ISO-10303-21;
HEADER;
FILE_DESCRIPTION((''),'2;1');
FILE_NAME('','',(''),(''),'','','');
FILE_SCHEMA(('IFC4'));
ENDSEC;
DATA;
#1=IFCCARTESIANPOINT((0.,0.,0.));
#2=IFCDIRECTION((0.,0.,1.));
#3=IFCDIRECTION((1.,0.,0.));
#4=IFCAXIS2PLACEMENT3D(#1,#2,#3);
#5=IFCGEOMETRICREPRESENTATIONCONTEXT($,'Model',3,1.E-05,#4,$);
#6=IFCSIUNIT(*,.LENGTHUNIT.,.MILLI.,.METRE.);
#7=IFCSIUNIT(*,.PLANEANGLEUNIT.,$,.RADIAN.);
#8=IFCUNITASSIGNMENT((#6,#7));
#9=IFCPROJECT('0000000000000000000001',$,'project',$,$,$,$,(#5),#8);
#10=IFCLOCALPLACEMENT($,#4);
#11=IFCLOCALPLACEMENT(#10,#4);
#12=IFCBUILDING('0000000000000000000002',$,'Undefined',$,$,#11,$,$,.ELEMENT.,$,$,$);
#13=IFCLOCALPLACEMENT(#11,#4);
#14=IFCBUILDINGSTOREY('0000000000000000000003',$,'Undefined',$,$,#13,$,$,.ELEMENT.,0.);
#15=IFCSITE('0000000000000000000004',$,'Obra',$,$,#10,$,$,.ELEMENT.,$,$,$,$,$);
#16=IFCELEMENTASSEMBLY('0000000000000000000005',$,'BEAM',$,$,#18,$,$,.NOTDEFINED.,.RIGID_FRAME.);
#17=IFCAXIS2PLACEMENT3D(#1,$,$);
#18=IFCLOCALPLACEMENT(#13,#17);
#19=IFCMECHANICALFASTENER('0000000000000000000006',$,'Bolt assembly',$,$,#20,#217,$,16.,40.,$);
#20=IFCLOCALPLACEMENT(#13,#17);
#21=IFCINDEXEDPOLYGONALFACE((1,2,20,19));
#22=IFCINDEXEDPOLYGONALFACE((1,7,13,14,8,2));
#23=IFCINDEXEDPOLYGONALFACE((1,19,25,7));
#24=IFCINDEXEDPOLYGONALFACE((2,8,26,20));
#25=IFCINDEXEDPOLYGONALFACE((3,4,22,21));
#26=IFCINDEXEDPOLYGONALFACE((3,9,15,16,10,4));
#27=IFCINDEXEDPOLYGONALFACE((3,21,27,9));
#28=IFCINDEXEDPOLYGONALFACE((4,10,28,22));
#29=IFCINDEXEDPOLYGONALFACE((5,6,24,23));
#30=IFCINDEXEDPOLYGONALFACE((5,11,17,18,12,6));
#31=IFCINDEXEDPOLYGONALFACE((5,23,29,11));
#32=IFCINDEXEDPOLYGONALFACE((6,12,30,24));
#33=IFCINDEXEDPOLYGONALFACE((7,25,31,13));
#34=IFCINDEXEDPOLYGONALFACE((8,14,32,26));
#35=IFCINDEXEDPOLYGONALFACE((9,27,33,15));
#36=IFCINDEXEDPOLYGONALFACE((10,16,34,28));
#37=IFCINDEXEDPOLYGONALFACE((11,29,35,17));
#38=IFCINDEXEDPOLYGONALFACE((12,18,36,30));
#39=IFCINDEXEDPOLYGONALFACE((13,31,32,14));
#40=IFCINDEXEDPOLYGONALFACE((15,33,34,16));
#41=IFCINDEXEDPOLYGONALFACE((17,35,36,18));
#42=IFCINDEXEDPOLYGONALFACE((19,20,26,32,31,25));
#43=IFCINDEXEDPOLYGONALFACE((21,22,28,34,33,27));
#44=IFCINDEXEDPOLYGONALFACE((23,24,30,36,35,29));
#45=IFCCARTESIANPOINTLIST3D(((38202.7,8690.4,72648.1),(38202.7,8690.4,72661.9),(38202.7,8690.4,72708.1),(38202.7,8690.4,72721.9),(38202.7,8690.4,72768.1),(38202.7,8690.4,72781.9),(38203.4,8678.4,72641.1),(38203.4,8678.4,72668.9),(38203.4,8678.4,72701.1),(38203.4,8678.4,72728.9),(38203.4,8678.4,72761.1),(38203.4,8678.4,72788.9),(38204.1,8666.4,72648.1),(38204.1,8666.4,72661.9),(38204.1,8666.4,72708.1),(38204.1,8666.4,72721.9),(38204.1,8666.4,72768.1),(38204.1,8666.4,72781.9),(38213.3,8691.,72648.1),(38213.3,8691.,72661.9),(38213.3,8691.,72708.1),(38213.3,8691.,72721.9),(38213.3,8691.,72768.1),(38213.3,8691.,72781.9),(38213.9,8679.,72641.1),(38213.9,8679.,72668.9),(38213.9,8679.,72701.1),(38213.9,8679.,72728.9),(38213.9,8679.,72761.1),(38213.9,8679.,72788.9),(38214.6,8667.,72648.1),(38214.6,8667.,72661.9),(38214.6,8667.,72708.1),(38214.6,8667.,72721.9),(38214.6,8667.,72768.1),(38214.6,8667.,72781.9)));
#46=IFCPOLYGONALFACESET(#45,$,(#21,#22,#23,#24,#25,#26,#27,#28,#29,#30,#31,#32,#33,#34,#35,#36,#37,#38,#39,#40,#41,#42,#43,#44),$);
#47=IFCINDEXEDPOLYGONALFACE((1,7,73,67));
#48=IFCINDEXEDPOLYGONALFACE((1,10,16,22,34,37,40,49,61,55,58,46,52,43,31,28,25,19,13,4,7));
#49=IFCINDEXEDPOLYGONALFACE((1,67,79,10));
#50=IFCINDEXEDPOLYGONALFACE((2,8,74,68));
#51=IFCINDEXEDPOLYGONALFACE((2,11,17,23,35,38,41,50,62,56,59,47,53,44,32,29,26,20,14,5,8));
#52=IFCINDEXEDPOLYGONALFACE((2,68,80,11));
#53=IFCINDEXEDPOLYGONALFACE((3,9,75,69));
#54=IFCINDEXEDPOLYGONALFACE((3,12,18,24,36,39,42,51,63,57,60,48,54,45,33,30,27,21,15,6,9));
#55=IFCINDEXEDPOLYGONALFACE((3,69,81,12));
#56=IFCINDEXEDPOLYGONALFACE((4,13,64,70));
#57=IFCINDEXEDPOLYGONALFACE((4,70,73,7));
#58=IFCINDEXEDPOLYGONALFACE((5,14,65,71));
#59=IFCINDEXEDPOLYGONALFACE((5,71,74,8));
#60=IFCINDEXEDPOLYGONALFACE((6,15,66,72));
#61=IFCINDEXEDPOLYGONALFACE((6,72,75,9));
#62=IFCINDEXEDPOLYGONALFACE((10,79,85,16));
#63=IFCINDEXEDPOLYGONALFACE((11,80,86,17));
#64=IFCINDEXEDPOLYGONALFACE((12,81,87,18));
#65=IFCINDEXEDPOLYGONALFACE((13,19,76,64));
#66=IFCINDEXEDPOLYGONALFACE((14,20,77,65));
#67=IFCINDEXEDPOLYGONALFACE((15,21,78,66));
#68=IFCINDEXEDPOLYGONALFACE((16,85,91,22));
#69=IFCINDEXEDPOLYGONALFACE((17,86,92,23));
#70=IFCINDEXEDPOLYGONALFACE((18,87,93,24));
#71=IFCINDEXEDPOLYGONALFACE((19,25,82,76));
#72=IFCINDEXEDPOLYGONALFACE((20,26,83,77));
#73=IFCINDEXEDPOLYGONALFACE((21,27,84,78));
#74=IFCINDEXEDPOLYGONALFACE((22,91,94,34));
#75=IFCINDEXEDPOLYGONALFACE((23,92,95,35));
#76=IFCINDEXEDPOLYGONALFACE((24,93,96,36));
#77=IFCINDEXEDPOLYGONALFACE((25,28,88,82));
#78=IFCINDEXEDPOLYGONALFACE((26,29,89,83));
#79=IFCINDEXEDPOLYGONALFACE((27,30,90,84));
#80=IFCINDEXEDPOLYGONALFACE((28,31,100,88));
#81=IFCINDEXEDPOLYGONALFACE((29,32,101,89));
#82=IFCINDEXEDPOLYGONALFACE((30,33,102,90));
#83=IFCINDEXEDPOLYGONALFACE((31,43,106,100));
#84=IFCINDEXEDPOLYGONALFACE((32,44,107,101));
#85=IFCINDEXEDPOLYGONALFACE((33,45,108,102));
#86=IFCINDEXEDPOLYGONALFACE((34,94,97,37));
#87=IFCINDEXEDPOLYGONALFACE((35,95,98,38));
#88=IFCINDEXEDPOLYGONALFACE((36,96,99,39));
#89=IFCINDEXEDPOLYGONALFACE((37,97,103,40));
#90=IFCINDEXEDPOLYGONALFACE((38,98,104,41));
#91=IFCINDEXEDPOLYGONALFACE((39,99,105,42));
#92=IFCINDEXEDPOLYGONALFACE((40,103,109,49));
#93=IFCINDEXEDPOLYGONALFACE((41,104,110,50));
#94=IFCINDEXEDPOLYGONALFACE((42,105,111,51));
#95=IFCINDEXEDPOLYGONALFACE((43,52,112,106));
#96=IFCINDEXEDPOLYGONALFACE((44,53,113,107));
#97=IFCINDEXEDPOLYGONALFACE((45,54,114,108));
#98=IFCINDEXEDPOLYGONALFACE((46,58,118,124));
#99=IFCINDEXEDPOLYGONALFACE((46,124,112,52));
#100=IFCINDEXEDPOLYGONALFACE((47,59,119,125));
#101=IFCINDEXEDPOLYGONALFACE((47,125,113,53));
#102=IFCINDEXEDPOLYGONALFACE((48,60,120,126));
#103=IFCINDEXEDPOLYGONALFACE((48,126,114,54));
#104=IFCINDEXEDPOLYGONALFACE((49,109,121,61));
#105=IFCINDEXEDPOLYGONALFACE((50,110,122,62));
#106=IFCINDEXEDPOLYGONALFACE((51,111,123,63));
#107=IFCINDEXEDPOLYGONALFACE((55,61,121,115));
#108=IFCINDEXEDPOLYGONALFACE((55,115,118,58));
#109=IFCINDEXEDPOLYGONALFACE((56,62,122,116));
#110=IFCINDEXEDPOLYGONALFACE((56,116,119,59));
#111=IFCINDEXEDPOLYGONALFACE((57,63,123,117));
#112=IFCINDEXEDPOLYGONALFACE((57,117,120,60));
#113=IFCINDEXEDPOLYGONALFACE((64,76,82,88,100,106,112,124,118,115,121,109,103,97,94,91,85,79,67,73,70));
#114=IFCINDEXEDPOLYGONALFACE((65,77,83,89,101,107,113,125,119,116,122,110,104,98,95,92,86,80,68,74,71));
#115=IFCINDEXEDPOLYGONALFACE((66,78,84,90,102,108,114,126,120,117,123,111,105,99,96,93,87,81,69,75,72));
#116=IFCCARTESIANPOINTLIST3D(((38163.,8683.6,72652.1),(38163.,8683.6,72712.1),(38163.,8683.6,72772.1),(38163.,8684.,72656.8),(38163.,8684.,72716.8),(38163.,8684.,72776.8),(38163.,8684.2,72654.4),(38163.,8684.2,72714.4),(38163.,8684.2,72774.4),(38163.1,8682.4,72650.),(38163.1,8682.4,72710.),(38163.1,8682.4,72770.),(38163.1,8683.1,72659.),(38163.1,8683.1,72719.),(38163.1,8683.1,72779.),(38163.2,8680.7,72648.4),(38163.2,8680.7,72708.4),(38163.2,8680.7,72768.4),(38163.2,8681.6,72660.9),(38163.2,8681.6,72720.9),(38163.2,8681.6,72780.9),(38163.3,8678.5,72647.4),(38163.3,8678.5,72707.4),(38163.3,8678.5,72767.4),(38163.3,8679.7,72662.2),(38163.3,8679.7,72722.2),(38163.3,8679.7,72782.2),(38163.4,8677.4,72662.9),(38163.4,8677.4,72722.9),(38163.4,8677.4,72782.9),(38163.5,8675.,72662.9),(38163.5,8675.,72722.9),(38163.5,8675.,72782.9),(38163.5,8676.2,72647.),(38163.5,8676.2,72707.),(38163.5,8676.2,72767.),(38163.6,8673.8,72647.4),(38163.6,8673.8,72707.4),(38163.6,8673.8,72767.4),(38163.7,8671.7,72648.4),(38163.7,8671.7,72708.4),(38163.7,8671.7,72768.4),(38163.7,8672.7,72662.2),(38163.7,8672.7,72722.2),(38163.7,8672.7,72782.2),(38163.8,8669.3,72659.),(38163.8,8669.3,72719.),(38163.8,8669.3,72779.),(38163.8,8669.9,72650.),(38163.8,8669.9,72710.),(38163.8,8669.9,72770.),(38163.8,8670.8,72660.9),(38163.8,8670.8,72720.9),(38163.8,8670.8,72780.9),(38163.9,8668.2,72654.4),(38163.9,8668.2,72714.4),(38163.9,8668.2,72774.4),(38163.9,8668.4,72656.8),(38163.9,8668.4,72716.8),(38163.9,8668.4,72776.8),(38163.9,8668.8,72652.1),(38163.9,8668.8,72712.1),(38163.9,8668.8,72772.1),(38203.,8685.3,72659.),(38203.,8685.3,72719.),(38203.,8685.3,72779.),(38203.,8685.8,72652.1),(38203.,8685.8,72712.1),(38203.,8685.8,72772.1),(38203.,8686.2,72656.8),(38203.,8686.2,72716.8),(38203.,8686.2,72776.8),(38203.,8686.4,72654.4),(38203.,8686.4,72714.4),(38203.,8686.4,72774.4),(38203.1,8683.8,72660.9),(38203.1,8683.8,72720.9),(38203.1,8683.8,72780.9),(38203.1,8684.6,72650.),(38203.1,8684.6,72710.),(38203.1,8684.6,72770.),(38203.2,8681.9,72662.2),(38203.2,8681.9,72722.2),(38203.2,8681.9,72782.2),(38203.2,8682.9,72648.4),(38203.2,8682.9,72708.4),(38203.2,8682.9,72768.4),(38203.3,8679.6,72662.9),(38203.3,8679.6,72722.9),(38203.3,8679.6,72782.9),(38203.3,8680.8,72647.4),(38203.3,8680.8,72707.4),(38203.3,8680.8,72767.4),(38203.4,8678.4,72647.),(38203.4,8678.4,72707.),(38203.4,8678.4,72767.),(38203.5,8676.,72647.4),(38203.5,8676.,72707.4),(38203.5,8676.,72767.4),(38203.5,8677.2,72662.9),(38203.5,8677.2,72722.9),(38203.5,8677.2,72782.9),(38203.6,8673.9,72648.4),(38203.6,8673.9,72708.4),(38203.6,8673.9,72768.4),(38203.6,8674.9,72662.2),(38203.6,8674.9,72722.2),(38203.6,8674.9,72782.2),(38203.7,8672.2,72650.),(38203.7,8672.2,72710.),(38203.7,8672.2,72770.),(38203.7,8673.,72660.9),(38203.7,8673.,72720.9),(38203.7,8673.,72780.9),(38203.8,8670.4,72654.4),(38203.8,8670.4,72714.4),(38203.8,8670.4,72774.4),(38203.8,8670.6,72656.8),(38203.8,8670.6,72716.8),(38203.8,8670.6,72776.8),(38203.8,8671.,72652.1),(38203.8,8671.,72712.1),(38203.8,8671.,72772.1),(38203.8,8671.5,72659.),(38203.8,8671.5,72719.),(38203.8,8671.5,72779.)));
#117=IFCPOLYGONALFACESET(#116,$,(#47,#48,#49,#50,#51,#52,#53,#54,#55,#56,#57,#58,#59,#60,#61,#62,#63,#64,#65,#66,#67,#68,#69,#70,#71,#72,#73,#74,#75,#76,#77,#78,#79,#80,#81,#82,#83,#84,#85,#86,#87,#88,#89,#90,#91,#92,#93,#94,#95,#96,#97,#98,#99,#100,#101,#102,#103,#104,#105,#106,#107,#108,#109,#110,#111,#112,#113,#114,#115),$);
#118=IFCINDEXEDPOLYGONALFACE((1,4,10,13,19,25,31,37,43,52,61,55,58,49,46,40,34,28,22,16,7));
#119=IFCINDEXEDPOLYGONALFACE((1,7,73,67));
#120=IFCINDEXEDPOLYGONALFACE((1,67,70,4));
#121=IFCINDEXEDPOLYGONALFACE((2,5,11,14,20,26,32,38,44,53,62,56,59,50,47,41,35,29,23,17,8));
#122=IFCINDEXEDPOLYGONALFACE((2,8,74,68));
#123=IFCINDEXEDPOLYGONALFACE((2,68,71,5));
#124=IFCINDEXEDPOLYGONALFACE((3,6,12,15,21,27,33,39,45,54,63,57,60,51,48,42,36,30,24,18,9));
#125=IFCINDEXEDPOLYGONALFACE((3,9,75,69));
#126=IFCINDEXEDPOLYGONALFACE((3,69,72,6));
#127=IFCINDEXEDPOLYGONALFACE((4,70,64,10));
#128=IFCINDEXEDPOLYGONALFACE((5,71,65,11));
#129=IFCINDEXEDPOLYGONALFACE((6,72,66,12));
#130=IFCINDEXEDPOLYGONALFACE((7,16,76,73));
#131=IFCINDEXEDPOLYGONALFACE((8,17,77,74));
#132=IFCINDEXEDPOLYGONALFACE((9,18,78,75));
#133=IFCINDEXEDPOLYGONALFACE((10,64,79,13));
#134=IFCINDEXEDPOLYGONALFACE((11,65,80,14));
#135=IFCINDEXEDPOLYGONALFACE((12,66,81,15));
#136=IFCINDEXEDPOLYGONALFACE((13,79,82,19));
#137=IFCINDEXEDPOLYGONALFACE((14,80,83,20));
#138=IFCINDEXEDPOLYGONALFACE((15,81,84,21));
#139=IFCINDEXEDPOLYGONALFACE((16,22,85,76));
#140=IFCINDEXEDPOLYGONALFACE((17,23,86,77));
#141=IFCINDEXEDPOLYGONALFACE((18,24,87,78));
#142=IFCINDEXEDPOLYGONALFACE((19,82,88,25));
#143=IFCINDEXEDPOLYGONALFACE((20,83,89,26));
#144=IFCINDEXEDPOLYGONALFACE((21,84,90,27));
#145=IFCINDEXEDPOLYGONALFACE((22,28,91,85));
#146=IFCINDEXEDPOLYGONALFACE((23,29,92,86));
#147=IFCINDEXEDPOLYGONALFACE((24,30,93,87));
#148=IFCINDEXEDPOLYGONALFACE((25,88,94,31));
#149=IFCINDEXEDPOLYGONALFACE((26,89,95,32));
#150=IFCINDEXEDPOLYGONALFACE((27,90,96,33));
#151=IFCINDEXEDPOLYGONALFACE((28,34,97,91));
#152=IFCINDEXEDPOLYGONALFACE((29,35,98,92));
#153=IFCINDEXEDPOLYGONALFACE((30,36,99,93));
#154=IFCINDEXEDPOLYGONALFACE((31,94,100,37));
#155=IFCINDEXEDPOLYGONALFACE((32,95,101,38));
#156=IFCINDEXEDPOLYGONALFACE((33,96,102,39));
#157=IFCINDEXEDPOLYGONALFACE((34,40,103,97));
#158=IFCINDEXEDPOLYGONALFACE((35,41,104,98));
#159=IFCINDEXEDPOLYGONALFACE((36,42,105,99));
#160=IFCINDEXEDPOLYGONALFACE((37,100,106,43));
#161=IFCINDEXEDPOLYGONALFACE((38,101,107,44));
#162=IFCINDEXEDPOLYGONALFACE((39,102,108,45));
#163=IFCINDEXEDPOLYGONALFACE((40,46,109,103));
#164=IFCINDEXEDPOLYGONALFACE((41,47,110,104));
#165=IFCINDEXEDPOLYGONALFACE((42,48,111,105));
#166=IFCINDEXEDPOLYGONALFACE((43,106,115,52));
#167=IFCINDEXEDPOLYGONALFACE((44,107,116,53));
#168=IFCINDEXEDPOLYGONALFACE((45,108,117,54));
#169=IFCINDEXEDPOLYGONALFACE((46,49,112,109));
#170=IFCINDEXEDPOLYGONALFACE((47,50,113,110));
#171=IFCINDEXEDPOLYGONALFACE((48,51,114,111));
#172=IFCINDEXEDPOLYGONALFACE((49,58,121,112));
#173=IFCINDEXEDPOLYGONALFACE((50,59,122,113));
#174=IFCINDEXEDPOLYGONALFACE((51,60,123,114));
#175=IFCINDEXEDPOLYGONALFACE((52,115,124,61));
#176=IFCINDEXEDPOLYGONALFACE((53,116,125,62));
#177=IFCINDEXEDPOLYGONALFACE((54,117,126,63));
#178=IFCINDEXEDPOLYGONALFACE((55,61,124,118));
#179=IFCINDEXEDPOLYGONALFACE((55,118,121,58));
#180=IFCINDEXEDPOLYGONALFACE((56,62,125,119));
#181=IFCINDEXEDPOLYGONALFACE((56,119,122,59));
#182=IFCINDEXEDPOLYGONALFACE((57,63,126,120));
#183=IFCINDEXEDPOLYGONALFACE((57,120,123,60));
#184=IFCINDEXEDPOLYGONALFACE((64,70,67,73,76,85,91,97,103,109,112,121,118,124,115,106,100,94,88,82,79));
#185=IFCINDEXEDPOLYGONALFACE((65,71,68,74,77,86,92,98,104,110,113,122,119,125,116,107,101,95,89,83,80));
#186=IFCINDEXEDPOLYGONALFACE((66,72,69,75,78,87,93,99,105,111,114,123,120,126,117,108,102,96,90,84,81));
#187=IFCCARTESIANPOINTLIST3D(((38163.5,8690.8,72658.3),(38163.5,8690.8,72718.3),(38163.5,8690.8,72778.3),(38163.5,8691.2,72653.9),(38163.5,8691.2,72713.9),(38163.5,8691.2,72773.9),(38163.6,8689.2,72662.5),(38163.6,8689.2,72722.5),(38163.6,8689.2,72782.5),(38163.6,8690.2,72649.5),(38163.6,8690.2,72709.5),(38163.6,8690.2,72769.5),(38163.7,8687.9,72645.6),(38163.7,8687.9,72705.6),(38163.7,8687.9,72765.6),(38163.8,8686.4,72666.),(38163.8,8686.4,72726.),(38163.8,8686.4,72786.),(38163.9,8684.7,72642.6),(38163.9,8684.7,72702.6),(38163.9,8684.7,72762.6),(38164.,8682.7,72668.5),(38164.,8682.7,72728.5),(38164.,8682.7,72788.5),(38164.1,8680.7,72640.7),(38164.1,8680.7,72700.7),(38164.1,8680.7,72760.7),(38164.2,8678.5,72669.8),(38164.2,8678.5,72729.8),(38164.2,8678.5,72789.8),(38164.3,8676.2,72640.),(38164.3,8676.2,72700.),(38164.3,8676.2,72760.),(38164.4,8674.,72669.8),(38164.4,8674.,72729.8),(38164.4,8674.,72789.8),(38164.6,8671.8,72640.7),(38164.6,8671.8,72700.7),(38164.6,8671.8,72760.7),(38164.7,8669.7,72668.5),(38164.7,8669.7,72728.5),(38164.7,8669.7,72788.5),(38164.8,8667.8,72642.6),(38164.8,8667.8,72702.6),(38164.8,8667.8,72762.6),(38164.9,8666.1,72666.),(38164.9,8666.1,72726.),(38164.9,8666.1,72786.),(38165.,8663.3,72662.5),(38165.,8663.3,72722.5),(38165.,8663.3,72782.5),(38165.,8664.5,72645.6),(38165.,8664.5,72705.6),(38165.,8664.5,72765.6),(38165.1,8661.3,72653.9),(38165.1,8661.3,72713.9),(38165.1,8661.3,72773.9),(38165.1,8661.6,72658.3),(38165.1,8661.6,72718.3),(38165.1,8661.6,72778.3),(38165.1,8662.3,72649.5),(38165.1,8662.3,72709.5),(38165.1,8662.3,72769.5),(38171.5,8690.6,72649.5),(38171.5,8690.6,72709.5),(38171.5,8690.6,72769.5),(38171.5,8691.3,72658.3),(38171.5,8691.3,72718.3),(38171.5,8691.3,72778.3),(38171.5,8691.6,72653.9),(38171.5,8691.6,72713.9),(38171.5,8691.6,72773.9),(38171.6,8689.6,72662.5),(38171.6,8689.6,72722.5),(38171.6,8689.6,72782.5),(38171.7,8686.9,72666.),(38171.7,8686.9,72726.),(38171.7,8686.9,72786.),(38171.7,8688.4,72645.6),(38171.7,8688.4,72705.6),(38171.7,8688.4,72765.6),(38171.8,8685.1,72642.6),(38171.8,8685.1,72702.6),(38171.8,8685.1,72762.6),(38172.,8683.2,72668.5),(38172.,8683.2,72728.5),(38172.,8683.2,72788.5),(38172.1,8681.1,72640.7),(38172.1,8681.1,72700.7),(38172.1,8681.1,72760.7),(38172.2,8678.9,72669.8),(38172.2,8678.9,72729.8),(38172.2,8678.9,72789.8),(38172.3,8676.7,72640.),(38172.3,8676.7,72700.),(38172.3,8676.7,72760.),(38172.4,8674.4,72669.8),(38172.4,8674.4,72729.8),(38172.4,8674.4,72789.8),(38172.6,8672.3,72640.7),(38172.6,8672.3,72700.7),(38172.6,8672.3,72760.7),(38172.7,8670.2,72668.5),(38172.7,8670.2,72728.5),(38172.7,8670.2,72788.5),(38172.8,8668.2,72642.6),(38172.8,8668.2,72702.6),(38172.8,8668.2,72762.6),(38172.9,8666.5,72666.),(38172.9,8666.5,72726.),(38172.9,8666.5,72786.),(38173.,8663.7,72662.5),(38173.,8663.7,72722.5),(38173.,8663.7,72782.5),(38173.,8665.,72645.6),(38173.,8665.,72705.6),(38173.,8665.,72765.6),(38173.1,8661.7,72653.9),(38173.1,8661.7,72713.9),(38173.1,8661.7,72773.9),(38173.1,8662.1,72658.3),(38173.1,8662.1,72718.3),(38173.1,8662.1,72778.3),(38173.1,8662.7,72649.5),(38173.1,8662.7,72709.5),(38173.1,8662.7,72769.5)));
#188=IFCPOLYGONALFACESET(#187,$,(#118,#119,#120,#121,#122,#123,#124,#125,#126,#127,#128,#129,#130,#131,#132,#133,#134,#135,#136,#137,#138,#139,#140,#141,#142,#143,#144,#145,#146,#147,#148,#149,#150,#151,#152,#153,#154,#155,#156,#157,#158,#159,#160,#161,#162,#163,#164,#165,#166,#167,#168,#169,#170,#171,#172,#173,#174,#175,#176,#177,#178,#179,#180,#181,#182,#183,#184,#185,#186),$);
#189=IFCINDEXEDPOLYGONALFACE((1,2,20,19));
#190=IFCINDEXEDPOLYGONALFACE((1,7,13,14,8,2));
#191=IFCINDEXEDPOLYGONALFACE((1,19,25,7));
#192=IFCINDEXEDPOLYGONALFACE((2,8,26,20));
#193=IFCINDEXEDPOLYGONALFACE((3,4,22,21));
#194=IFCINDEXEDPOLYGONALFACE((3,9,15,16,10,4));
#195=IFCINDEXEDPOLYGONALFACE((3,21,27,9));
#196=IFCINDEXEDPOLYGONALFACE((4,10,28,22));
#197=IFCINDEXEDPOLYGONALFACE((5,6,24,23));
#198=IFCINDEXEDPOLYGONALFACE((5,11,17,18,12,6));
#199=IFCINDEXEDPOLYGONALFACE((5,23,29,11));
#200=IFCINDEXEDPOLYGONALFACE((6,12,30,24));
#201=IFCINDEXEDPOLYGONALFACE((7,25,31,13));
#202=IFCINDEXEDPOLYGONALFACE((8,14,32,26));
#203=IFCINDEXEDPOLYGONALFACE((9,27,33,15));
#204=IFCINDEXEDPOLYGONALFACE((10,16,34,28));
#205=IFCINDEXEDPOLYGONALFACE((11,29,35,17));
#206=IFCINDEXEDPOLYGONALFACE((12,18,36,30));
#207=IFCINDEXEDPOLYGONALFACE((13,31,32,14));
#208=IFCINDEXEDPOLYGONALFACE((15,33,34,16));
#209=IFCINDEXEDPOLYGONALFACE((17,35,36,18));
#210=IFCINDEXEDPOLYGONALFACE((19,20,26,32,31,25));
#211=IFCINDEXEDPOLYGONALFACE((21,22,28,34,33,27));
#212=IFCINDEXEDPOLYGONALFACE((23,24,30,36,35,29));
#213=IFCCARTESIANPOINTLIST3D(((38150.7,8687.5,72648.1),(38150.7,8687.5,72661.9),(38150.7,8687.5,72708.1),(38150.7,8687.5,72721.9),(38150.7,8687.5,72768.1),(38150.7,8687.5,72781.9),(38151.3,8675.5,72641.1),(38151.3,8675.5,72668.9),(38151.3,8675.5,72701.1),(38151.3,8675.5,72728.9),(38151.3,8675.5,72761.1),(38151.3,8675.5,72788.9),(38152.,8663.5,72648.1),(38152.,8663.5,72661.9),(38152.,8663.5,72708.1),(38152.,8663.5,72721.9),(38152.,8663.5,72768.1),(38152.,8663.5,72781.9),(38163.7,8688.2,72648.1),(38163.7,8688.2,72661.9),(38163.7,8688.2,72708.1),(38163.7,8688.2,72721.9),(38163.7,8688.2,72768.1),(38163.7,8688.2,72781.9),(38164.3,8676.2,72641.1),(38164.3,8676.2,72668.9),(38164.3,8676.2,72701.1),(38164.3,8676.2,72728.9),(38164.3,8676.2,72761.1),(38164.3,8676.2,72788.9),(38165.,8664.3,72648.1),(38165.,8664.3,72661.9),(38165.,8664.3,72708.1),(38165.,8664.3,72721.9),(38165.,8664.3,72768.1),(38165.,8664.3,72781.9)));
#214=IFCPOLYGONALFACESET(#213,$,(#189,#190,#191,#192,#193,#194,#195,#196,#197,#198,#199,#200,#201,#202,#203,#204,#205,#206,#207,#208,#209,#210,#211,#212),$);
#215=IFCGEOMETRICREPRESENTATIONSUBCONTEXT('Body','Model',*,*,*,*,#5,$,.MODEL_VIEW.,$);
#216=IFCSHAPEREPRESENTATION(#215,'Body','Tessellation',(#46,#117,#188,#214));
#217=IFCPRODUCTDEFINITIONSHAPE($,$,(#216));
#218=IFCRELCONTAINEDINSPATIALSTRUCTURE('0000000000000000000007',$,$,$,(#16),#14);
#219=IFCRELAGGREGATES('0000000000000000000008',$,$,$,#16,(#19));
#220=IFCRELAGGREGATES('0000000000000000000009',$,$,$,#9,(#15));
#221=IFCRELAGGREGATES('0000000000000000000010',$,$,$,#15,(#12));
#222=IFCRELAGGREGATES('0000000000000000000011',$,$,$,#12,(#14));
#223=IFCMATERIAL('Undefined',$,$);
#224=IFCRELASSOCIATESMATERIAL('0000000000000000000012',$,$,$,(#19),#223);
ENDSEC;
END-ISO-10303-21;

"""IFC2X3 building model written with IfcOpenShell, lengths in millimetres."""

from ifc_helpers import new_model, si_unit, frame, origin_with_axes, origin_2d_with_axis, place, context, subcontext, project, spatial, polyline, circle, outline, extrude, source, transform, mapped, material, element, aggregate, save


model = new_model("IFC2X3")

# Units and contexts
model_context = context("Model", 3, precision=1e-05, world=origin_with_axes())
body_context = subcontext(model_context, "Body", "Model", "MODEL_VIEW")
ifc_project = project(units=[si_unit("LENGTHUNIT", "METRE", prefix="MILLI"), si_unit("PLANEANGLEUNIT", "RADIAN")], contexts=[model_context])

# Site, building, storey
site_placement = place(None, origin_with_axes())
site = spatial("IfcSite", under=ifc_project, at=site_placement, Name="Obra", CompositionType="ELEMENT")
building_placement = place(site_placement, origin_with_axes())
building = spatial("IfcBuilding", under=site, at=building_placement, Name="Undefined", CompositionType="ELEMENT")
storey_placement = place(building_placement, origin_with_axes())
storey = spatial("IfcBuildingStorey", under=building, at=storey_placement, Name="Undefined", CompositionType="ELEMENT", Elevation=0.0)

# Element assembly
assembly_1_placement = place(storey_placement, origin_with_axes())
assembly_1 = element("IfcElementAssembly", 1, at=assembly_1_placement, inside=storey, Name="BEAM", AssemblyPlace="NOTDEFINED", PredefinedType="RIGID_FRAME")

# Shared definitions
ifc_material_1 = material(Name="Undefined")
shared_shape_1 = source(origin_with_axes(), body_context, "Body", "SweptSolid", [
    extrude(outline(polyline([(13.9, 0.0), (6.9, 12.0), (-6.9, 12.0), (-13.9, 0.0), (-6.9, -12.0), (6.9, -12.0), (13.9, 0.0)])), frame((0.0, -44.8, 0.0), z_axis=(0.0, 1.0, 0.0), x_axis=(1.0, 0.0, 0.0)), (0.0, 0.0, 1.0), 10.6),
    extrude(circle(Radius=8.0, at=origin_2d_with_axis()), frame((0.0, -34.2, 0.0), z_axis=(0.0, 1.0, 0.0), x_axis=(1.0, 0.0, 0.0)), (0.0, 0.0, 1.0), 40.0),
    extrude(circle(Radius=15.0, at=origin_2d_with_axis()), frame((0.0, -3.1, 0.0), z_axis=(0.0, 1.0, 0.0), x_axis=(1.0, 0.0, 0.0)), (0.0, 0.0, 1.0), 8.0),
    extrude(outline(polyline([(13.9, 0.0), (6.9, 12.0), (-6.9, 12.0), (-13.9, 0.0), (-6.9, -12.0), (6.9, -12.0), (13.9, 0.0)])), frame((0.0, 4.9, 0.0), z_axis=(0.0, 1.0, 0.0), x_axis=(1.0, 0.0, 0.0)), (0.0, 0.0, 1.0), 13.0),
])

# Mechanical fastener
mechanical_fastener_1_placement = place(assembly_1_placement, frame((38172.0, 8626.6, 72835.0), z_axis=(-0.055152, 0.998478, 0.0), x_axis=(0.0, 0.0, -1.0)))
mechanical_fastener_1 = element("IfcMechanicalFastener", 2, at=mechanical_fastener_1_placement, material=ifc_material_1, Name="Bolt assembly", NominalDiameter=16.0, NominalLength=40.0, context=body_context, shape_type="MappedRepresentation", body=[
    mapped(shared_shape_1, transform((60.0, 0.0, 50.0))),
    mapped(shared_shape_1, transform((120.0, 0.0, 50.0))),
    mapped(shared_shape_1, transform((180.0, 0.0, 50.0))),
])
aggregate(assembly_1, [mechanical_fastener_1])

save(model, "model.ifc")
